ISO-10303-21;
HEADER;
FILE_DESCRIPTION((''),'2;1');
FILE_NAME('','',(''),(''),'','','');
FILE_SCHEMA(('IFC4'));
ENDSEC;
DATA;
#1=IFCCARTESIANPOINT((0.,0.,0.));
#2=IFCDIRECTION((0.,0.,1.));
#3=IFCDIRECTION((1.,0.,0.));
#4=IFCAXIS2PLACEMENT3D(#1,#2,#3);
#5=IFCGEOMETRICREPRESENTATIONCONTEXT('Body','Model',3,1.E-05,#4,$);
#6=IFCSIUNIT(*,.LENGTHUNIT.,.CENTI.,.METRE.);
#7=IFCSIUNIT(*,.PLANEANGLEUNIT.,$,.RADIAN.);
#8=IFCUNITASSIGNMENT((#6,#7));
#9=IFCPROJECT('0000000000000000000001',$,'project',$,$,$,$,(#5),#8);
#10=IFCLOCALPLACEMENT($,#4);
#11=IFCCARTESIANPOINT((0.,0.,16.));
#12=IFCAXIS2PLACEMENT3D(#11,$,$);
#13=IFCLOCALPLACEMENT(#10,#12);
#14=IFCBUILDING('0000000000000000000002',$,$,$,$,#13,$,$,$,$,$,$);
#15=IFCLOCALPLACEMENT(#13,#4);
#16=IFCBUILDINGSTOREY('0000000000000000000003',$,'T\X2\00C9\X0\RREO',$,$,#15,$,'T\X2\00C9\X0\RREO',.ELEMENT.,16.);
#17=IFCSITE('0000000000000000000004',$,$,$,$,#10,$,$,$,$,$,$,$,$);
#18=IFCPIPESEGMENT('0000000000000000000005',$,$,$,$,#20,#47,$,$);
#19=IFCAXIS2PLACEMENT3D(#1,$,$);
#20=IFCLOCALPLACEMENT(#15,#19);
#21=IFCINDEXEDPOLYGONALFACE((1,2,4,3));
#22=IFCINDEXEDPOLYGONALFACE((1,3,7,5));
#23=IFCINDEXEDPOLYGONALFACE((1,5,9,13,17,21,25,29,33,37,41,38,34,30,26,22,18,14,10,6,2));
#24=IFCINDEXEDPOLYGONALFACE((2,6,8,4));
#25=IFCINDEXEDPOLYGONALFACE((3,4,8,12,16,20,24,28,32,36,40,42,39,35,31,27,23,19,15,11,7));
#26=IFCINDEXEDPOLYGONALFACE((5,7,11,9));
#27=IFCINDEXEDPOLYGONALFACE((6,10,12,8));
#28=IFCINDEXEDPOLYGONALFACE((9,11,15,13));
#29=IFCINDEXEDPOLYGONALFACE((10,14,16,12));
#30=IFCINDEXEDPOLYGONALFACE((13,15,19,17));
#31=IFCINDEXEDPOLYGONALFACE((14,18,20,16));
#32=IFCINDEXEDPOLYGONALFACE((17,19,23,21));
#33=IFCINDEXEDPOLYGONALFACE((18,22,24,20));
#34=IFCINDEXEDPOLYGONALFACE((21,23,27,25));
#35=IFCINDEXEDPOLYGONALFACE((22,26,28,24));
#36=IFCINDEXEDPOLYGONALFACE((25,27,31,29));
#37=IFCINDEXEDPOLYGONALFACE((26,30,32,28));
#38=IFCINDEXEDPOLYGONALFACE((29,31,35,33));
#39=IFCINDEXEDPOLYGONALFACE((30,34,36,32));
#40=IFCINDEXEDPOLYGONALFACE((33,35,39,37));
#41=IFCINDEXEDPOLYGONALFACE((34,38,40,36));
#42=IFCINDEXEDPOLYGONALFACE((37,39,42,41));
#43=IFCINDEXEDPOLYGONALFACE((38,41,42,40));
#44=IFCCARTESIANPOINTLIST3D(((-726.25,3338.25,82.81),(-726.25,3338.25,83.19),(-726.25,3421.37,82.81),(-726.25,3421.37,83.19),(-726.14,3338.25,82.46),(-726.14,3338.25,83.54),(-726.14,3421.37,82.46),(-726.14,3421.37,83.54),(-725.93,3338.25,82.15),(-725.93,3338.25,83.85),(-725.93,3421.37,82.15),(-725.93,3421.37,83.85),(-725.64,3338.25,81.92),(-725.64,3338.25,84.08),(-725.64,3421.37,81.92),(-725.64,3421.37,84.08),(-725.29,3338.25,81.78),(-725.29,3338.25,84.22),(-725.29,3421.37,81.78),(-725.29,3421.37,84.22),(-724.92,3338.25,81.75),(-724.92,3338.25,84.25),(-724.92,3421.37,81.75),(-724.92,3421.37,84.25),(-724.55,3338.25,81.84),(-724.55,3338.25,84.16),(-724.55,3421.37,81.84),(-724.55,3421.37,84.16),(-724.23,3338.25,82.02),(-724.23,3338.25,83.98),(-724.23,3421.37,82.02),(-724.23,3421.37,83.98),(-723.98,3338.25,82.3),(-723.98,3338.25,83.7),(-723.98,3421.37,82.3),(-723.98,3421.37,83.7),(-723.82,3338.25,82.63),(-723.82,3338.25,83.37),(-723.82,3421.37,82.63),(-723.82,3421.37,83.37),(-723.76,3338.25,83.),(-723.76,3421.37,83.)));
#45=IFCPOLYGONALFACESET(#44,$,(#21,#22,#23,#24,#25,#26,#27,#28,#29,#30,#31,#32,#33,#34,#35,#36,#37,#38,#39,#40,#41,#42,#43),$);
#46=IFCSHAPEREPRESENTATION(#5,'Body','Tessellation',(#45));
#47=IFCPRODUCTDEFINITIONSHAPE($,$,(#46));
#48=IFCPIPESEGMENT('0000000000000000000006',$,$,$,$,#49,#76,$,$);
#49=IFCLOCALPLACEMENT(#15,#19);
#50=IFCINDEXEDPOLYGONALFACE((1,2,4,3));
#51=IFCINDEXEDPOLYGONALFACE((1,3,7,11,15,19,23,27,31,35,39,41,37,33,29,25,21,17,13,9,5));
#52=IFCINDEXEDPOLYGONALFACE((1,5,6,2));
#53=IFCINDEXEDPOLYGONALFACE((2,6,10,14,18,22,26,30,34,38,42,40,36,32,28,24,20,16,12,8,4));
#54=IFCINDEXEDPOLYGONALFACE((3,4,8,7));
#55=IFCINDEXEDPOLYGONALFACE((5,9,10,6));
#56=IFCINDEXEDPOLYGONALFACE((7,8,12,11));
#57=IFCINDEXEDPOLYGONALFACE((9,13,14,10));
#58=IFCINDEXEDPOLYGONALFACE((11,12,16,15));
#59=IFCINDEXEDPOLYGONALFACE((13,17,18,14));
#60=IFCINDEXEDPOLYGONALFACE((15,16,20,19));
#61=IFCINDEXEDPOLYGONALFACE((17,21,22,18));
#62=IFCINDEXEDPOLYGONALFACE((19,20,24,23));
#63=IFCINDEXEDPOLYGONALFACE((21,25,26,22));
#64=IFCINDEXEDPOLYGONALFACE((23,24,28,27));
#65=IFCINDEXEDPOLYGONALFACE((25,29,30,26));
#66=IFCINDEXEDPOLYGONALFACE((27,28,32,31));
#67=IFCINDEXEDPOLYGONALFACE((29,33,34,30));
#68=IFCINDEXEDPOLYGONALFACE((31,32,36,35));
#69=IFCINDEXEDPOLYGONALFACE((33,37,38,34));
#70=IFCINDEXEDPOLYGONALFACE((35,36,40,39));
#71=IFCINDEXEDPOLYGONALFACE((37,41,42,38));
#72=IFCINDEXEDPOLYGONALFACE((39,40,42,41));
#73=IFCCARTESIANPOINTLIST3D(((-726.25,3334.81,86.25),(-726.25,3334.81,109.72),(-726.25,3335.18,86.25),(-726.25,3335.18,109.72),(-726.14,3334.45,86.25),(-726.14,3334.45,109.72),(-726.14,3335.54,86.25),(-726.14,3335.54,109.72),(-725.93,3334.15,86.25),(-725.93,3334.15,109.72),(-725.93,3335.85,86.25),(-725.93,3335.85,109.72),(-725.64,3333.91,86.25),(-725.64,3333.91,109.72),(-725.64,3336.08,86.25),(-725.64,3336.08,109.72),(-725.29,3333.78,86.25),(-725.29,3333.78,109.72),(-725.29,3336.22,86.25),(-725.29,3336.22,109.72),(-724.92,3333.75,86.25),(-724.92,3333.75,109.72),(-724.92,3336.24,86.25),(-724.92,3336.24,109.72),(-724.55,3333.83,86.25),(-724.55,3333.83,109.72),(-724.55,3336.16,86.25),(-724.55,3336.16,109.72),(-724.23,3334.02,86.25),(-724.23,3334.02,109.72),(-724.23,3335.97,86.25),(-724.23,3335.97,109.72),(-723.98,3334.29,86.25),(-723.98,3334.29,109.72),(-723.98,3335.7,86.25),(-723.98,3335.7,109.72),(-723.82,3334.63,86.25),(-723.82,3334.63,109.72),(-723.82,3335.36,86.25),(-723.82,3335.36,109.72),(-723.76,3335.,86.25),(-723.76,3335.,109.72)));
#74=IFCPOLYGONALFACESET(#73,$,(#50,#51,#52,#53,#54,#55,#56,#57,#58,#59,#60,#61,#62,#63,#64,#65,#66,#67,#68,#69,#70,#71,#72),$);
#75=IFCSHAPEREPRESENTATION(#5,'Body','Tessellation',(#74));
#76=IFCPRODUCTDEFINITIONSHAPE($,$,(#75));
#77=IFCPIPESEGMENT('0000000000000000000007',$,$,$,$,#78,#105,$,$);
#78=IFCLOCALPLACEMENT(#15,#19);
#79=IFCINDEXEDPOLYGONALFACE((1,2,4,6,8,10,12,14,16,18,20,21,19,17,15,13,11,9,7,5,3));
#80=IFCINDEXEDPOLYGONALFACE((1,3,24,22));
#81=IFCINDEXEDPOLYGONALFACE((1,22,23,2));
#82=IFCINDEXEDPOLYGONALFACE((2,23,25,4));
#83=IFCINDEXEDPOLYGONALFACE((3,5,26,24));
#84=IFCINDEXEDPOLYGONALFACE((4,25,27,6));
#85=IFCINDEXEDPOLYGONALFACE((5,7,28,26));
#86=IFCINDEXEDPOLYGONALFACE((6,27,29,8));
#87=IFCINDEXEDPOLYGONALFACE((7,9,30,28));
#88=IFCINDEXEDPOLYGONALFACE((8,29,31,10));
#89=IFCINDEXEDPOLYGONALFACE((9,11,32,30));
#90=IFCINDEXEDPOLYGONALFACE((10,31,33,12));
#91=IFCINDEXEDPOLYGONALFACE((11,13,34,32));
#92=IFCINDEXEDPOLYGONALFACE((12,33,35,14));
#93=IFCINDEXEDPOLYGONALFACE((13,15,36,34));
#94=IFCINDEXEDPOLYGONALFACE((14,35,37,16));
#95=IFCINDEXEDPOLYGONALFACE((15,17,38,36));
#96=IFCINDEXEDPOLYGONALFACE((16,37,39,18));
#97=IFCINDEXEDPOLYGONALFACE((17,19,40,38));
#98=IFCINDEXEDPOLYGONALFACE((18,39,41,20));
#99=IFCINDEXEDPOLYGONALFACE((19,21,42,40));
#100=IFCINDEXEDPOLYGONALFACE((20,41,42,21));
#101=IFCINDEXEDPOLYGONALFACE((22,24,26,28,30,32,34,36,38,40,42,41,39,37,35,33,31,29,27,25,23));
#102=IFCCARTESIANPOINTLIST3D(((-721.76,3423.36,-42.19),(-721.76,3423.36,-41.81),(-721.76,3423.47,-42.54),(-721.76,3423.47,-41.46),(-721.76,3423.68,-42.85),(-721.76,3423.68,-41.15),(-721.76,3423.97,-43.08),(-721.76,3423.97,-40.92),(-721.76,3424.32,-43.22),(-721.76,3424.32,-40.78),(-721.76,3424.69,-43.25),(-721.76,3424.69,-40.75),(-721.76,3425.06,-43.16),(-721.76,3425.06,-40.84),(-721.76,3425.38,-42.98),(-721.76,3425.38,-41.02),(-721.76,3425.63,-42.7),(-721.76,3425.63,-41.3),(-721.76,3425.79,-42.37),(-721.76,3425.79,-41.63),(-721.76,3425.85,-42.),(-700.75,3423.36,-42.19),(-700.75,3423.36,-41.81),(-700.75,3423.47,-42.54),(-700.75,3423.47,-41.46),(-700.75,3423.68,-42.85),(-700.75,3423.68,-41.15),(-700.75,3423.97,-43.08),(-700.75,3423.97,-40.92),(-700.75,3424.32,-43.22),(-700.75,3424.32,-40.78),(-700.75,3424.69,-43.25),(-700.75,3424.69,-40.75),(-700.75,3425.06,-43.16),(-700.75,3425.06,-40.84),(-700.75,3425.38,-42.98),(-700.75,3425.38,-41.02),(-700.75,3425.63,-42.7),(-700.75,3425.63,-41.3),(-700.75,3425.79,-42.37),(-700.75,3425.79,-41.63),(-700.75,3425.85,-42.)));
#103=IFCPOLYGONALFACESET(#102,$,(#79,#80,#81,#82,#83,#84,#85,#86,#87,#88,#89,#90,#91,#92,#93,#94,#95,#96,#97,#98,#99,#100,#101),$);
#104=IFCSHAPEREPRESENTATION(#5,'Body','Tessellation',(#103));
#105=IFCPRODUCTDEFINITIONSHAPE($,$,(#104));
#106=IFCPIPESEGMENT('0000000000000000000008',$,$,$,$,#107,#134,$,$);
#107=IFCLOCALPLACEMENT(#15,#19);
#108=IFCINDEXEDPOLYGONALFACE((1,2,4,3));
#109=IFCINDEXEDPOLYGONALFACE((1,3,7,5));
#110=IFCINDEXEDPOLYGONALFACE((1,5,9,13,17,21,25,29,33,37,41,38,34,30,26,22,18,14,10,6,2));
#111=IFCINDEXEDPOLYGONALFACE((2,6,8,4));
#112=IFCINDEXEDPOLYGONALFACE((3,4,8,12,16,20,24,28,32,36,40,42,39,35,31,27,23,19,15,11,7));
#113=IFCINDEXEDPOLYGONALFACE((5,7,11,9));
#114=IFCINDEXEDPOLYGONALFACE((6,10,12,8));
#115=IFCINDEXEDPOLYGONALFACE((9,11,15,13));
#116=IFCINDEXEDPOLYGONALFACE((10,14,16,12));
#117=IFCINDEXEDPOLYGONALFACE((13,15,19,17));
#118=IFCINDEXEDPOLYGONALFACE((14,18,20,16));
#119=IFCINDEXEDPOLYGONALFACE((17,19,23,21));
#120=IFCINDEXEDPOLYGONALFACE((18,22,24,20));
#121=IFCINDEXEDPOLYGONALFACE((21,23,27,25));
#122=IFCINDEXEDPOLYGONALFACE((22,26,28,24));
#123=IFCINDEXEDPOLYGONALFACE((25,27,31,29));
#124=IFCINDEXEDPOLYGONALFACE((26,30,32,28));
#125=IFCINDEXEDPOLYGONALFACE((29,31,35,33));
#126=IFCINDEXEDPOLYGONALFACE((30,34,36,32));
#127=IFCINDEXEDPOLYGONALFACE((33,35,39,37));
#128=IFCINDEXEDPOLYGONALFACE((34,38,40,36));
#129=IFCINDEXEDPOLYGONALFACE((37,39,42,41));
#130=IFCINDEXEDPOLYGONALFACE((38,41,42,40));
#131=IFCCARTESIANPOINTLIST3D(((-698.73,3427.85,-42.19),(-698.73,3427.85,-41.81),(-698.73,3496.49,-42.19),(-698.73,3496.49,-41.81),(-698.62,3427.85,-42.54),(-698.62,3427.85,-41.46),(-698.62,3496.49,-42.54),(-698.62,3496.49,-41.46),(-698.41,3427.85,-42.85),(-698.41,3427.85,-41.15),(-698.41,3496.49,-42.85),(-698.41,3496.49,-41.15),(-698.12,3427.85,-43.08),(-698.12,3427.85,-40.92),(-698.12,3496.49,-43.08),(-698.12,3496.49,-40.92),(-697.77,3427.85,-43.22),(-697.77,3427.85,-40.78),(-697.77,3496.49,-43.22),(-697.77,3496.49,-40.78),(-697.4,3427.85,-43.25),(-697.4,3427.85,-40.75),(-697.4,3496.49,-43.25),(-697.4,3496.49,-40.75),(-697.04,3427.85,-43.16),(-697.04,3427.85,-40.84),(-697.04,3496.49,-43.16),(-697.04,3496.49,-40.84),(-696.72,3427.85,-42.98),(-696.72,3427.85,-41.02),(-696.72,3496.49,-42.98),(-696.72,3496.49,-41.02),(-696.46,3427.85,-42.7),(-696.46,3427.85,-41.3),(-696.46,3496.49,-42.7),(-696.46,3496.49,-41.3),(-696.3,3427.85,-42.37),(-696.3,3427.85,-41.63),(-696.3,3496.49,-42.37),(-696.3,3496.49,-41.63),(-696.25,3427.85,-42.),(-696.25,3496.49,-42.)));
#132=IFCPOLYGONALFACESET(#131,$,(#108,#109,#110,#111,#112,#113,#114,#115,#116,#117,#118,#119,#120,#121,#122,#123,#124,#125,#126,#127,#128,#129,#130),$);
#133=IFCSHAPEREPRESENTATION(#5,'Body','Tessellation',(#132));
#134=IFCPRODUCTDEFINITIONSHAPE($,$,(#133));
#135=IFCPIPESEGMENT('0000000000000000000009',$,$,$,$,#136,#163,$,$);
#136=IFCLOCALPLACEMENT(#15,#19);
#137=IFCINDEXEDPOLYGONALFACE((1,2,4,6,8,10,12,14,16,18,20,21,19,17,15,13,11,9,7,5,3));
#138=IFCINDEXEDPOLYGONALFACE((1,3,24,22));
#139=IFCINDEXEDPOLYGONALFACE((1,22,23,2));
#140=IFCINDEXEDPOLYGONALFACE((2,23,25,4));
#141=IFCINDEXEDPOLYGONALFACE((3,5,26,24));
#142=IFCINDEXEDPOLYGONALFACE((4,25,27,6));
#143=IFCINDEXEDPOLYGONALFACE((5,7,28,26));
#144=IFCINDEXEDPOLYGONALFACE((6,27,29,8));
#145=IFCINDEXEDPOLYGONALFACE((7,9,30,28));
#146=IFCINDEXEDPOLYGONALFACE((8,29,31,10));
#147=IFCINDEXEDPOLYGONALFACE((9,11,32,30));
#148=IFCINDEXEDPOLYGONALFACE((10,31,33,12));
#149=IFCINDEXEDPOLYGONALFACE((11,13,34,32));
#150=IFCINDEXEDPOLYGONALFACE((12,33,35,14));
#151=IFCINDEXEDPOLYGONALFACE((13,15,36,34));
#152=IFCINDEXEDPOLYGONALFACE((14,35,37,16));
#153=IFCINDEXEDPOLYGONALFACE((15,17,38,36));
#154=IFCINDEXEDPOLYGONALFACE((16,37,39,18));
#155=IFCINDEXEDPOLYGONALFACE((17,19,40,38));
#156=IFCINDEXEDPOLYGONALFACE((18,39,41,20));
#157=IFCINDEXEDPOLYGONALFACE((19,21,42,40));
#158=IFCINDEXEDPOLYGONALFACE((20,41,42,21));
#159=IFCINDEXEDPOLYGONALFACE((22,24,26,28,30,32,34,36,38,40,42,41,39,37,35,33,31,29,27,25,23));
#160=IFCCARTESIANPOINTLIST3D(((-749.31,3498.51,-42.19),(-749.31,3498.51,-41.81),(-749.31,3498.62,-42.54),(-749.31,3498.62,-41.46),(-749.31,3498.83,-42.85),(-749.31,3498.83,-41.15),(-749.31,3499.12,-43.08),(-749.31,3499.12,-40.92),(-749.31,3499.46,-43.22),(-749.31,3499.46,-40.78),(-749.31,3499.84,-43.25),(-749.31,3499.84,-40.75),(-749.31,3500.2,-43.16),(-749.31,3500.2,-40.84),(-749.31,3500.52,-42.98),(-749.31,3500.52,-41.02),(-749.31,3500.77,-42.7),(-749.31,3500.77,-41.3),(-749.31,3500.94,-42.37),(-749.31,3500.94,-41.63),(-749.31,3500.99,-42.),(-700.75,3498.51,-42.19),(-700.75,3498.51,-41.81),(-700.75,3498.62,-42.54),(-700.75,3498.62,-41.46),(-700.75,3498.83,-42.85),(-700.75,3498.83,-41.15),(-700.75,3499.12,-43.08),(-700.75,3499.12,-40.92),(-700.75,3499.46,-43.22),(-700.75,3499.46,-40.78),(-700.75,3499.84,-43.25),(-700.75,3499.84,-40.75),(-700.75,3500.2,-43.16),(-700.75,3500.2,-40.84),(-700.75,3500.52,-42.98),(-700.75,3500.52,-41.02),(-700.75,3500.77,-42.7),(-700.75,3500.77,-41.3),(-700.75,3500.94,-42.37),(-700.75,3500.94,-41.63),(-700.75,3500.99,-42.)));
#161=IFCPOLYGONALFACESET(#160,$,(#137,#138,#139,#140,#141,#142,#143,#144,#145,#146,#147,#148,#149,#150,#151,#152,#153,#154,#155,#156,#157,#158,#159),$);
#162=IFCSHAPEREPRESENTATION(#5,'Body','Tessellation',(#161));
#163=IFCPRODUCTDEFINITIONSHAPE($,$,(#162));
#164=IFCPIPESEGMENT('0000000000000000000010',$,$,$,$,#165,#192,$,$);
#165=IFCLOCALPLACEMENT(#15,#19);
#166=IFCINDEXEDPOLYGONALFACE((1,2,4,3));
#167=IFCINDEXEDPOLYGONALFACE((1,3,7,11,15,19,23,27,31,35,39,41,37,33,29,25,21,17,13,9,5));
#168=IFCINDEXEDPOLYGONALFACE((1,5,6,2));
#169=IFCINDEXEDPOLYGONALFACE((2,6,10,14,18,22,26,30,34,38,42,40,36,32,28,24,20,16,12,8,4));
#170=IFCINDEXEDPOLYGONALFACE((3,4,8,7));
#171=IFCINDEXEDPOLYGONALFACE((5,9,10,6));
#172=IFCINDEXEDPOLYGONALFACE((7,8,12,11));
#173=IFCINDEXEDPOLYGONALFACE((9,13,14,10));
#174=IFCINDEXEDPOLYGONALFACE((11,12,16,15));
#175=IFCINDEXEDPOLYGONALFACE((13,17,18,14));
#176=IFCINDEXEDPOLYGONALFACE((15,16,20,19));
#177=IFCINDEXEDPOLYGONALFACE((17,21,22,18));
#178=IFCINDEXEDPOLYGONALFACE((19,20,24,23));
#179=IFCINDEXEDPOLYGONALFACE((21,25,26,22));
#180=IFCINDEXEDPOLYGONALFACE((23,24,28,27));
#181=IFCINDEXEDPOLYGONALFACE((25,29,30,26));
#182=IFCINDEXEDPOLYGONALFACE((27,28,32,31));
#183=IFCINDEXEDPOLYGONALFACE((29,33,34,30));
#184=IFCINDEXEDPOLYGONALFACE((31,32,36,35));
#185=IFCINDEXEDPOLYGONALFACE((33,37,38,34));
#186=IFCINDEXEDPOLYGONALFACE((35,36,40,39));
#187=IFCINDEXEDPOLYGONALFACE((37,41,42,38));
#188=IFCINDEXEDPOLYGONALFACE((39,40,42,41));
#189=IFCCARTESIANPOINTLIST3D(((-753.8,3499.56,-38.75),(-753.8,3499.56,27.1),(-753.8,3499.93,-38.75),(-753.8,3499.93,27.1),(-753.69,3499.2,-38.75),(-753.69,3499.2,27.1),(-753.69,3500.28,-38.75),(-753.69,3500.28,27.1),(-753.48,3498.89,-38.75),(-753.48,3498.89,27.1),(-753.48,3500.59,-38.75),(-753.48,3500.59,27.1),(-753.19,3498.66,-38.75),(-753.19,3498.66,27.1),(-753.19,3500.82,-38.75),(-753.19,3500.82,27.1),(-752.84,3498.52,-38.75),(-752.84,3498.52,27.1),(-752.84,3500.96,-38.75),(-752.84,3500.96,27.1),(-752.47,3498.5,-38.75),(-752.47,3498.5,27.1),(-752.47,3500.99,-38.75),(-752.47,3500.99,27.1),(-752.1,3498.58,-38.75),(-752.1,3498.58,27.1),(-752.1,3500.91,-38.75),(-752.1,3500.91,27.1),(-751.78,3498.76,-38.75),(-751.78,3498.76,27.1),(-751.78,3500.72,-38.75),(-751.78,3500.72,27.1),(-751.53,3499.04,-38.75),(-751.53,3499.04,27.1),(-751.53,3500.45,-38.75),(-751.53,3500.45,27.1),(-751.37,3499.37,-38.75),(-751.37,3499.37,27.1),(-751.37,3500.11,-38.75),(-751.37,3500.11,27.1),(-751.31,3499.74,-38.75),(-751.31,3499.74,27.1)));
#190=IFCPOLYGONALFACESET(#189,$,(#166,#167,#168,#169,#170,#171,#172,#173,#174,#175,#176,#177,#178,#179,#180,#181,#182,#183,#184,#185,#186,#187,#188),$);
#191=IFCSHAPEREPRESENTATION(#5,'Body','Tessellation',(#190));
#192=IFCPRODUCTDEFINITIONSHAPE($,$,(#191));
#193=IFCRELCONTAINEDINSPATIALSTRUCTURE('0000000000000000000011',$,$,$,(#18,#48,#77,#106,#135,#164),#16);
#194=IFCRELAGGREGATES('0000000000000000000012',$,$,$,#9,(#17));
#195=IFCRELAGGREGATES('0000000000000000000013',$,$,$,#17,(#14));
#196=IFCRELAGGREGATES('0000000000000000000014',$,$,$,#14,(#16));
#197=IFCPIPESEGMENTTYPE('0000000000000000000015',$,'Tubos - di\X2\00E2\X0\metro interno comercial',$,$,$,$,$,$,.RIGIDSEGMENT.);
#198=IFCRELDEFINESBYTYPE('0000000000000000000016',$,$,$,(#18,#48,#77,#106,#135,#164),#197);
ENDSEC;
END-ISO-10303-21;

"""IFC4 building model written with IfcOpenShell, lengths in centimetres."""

from ifc_helpers import new_model, si_unit, frame, origin_with_axes, origin_2d_with_axis, place, context, project, spatial, circle, extrude, type_object, element, save


model = new_model("IFC4")

# Units and contexts
model_context = context("Model", 3, precision=1e-05, world=origin_with_axes(), identifier="Body")
ifc_project = project(units=[si_unit("LENGTHUNIT", "METRE", prefix="CENTI"), si_unit("PLANEANGLEUNIT", "RADIAN")], contexts=[model_context])

# Site, building, storey
site_placement = place(None, origin_with_axes())
site = spatial("IfcSite", under=ifc_project, at=site_placement)
building_placement = place(site_placement, frame((0.0, 0.0, 16.0)))
building = spatial("IfcBuilding", under=site, at=building_placement)
storey_placement = place(building_placement, origin_with_axes())
storey = spatial("IfcBuildingStorey", under=building, at=storey_placement, Name="TÉRREO", LongName="TÉRREO", CompositionType="ELEMENT", Elevation=16.0)

# Pipe segments
pipe_segment_type = type_object("IfcPipeSegmentType", Name="Tubos - diâmetro interno comercial", PredefinedType="RIGIDSEGMENT")
pipe_segment_1_placement = place(storey_placement, frame((-725.01, 3379.81, 84.25), z_axis=(0.0, 0.0, 1.0), x_axis=(1.0, 0.0, 0.0)))
element("IfcPipeSegment", 1, at=pipe_segment_1_placement, inside=storey, type_object=pipe_segment_type, context=model_context, shape_type="SolidModel", body=[
    extrude(circle(Radius=1.25, at=origin_2d_with_axis()), frame((0.0, 41.56, -1.25), z_axis=(0.0, -1.0, 0.0), x_axis=(1.0, 0.0, 0.0)), (0.0, 0.0, 1.0), 83.13),
])
pipe_segment_2_placement = place(storey_placement, frame((-725.01, 3335.0, 109.72), z_axis=(0.0, 0.0, 1.0), x_axis=(1.0, 0.0, 0.0)))
element("IfcPipeSegment", 2, at=pipe_segment_2_placement, inside=storey, type_object=pipe_segment_type, context=model_context, shape_type="SolidModel", body=[
    extrude(circle(Radius=1.25, at=origin_2d_with_axis()), frame((0.0, 0.0, -23.47), z_axis=(0.0, 0.0, 1.0), x_axis=(1.0, 0.0, 0.0)), (0.0, 0.0, 1.0), 23.47),
])
pipe_segment_3_placement = place(storey_placement, frame((-711.25, 3424.6, -40.75), z_axis=(0.0, 0.0, 1.0), x_axis=(1.0, 0.0, 0.0)))
element("IfcPipeSegment", 3, at=pipe_segment_3_placement, inside=storey, type_object=pipe_segment_type, context=model_context, shape_type="SolidModel", body=[
    extrude(circle(Radius=1.25, at=origin_2d_with_axis()), frame((-10.51, 0.0, -1.25), z_axis=(1.0, 0.0, 0.0), x_axis=(0.0, 1.0, 0.0)), (0.0, 0.0, 1.0), 21.02),
])
pipe_segment_4_placement = place(storey_placement, frame((-697.5, 3462.17, -40.75), z_axis=(0.0, 0.0, 1.0), x_axis=(1.0, 0.0, 0.0)))
element("IfcPipeSegment", 4, at=pipe_segment_4_placement, inside=storey, type_object=pipe_segment_type, context=model_context, shape_type="SolidModel", body=[
    extrude(circle(Radius=1.25, at=origin_2d_with_axis()), frame((0.0, -34.32, -1.25), z_axis=(0.0, 1.0, 0.0), x_axis=(1.0, 0.0, 0.0)), (0.0, 0.0, 1.0), 68.64),
])
pipe_segment_5_placement = place(storey_placement, frame((-725.03, 3499.74, -40.75), z_axis=(0.0, 0.0, 1.0), x_axis=(1.0, 0.0, 0.0)))
element("IfcPipeSegment", 5, at=pipe_segment_5_placement, inside=storey, type_object=pipe_segment_type, context=model_context, shape_type="SolidModel", body=[
    extrude(circle(Radius=1.25, at=origin_2d_with_axis()), frame((24.28, 0.0, -1.25), z_axis=(-1.0, 0.0, 0.0), x_axis=(0.0, 1.0, 0.0)), (0.0, 0.0, 1.0), 48.56),
])
pipe_segment_6_placement = place(storey_placement, frame((-752.56, 3499.74, 27.1), z_axis=(0.0, 0.0, 1.0), x_axis=(1.0, 0.0, 0.0)))
element("IfcPipeSegment", 6, at=pipe_segment_6_placement, inside=storey, type_object=pipe_segment_type, context=model_context, shape_type="SolidModel", body=[
    extrude(circle(Radius=1.25, at=origin_2d_with_axis()), frame((0.0, 0.0, -65.85), z_axis=(0.0, 0.0, 1.0), x_axis=(1.0, 0.0, 0.0)), (0.0, 0.0, 1.0), 65.85),
])

save(model, "model.ifc")
